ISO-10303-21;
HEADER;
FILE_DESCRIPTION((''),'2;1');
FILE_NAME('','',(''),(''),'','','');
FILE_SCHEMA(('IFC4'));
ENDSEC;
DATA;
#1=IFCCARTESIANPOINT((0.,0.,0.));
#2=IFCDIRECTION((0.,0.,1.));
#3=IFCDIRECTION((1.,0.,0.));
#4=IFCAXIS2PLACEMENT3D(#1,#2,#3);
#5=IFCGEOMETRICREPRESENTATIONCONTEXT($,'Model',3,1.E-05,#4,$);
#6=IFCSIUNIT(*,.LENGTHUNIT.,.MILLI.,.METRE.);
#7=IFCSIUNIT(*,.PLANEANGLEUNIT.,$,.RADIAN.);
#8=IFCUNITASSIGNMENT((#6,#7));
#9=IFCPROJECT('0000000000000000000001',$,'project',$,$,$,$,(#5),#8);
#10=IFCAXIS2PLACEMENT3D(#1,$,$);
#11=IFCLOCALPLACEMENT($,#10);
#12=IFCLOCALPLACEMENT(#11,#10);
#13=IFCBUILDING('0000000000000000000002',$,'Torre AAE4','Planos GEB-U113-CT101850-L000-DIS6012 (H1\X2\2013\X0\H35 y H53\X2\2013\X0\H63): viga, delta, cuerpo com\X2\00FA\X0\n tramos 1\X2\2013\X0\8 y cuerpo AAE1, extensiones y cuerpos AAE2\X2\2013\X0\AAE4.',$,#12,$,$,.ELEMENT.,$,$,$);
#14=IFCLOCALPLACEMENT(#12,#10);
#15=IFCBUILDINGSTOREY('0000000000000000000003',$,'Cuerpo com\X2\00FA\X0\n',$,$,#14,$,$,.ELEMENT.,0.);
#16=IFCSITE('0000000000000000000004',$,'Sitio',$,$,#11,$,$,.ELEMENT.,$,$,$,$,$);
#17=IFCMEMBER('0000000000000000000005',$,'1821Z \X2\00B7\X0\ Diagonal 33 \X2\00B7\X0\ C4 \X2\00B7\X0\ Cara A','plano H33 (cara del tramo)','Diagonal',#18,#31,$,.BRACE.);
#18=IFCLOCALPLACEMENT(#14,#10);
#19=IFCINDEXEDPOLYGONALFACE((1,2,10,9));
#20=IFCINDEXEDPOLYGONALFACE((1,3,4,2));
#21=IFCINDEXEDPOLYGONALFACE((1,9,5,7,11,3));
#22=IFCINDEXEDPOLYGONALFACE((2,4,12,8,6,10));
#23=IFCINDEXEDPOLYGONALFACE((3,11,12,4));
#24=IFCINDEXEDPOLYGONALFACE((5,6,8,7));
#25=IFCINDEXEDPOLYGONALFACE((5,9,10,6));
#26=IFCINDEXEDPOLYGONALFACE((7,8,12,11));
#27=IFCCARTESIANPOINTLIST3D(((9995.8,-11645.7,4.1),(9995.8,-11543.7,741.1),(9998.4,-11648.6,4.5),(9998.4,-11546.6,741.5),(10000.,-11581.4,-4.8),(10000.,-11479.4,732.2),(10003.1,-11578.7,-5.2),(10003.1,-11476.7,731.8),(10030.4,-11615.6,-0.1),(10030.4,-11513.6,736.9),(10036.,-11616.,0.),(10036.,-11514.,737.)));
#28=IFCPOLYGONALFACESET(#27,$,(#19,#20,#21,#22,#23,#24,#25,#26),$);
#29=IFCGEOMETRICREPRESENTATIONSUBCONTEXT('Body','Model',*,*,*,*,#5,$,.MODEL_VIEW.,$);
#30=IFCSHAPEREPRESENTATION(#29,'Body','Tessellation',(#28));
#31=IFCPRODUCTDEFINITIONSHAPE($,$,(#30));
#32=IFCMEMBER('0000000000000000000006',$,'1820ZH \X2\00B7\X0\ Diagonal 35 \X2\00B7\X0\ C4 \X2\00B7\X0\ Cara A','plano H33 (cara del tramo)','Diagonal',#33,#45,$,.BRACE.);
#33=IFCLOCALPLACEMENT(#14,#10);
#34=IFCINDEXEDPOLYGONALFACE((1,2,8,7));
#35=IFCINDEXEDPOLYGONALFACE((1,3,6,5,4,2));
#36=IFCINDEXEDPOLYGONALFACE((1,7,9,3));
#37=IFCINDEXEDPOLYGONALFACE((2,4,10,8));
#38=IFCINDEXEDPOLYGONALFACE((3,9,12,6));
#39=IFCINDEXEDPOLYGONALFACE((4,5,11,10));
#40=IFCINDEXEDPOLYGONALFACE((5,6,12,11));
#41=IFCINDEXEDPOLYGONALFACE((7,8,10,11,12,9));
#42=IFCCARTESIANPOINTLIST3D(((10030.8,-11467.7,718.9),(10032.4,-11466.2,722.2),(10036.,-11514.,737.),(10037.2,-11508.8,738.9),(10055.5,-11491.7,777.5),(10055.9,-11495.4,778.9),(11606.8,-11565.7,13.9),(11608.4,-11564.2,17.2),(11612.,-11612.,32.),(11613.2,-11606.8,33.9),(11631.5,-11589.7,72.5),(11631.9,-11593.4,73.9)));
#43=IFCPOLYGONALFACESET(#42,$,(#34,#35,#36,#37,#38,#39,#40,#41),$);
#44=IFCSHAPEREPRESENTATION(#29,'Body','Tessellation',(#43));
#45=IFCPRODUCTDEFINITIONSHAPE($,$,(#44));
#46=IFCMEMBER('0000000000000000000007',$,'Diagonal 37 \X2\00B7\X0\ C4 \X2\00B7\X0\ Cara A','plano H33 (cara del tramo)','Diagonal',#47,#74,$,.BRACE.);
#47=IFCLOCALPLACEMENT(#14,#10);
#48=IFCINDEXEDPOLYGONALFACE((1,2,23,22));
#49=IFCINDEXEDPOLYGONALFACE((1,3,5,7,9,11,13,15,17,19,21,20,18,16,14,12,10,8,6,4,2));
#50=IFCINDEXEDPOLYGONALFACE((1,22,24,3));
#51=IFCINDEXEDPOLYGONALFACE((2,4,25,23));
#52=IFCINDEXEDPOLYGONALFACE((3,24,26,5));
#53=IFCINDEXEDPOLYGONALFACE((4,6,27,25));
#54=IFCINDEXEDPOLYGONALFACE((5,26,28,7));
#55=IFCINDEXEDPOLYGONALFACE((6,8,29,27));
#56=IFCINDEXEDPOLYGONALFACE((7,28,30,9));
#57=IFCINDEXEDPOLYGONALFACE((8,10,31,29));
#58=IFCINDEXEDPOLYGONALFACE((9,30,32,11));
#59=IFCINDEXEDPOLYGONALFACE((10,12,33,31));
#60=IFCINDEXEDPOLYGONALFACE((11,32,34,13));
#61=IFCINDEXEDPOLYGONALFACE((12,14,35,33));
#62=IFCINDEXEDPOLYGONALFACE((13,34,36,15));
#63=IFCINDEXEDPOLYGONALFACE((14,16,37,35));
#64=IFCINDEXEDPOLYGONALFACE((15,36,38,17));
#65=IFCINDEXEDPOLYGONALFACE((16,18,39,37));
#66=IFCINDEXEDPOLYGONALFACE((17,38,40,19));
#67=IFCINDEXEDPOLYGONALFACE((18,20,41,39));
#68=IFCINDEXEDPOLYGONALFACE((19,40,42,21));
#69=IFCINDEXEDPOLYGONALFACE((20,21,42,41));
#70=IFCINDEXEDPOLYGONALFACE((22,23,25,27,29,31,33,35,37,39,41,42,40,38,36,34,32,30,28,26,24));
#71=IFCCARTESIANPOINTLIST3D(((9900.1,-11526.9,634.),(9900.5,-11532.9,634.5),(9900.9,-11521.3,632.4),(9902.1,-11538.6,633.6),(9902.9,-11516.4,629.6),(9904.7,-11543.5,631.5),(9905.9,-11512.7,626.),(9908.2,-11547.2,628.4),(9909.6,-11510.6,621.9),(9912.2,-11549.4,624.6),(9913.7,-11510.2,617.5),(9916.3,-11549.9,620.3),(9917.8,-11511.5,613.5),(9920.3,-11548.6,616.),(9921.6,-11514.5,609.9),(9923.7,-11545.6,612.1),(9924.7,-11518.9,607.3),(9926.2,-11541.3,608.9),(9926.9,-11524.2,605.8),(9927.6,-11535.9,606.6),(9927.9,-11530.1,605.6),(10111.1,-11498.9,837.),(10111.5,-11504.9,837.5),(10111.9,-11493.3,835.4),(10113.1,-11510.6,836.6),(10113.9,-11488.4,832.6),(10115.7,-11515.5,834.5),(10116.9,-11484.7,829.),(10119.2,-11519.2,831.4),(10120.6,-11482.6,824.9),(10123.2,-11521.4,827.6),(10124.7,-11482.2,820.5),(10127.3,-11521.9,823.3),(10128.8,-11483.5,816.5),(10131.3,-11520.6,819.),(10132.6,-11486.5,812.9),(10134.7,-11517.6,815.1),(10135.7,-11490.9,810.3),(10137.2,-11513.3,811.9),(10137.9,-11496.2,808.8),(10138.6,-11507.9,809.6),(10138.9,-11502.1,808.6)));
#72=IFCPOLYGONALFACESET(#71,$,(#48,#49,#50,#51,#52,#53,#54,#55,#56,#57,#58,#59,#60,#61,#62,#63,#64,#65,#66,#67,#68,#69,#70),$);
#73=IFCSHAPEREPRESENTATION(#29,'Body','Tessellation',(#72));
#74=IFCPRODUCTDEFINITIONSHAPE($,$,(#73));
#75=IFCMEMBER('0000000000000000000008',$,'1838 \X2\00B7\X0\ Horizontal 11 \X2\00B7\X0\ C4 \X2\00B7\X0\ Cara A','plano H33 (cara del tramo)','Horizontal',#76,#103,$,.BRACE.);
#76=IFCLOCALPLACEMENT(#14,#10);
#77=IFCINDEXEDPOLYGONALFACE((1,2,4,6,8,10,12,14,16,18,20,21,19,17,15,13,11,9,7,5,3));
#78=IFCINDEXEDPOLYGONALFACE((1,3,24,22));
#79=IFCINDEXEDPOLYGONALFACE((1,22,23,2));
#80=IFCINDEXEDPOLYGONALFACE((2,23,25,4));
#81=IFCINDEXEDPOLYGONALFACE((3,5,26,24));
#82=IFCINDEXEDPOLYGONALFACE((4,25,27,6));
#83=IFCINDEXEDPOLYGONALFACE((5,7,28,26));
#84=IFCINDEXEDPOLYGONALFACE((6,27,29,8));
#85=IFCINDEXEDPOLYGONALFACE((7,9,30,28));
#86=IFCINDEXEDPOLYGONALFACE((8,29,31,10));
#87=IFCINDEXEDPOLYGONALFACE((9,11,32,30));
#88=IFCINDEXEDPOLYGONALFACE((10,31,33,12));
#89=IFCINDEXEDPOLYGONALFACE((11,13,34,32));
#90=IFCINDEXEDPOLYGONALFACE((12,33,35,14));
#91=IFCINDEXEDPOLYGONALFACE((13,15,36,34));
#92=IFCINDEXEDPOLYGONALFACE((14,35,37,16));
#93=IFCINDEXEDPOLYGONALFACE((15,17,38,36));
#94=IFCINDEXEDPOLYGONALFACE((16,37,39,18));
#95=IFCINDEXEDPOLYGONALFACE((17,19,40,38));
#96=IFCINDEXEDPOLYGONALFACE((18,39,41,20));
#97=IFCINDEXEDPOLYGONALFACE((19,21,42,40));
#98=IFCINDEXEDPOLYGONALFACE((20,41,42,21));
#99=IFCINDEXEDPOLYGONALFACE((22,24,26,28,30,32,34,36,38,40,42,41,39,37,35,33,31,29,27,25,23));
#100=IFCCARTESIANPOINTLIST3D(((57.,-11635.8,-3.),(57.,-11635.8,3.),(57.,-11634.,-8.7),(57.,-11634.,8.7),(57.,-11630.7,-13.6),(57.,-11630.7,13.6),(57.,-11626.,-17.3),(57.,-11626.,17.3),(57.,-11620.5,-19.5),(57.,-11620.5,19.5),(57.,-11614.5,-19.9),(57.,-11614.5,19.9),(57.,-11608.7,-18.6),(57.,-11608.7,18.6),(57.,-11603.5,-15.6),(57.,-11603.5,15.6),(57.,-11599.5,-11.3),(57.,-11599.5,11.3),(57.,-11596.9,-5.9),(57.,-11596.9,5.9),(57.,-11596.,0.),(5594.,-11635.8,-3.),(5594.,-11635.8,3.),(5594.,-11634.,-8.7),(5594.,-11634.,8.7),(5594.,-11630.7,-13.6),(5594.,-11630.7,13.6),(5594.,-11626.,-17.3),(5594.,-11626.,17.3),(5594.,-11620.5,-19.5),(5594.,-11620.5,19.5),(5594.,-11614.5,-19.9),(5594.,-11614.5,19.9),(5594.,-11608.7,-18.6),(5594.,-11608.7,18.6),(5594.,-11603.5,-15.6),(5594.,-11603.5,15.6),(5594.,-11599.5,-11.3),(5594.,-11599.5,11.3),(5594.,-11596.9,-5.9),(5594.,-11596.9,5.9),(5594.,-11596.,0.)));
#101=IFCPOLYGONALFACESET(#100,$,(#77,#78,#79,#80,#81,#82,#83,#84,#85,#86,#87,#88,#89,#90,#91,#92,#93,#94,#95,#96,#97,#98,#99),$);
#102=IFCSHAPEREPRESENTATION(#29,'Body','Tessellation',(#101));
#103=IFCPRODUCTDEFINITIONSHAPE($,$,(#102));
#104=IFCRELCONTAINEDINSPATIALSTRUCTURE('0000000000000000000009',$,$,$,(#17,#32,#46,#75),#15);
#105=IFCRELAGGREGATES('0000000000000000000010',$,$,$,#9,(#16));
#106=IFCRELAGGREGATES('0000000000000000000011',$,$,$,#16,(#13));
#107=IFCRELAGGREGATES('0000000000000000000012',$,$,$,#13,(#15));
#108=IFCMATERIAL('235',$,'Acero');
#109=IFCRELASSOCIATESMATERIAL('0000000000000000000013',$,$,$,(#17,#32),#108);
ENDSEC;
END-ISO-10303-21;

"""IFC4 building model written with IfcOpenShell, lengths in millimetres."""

from ifc_helpers import new_model, si_unit, frame, frame_2d, origin, origin_with_axes, place, context, subcontext, project, spatial, circle, l_section, extrude, material, element, save


model = new_model("IFC4")

# Units and contexts
model_context = context("Model", 3, precision=1e-05, world=origin_with_axes())
body_context = subcontext(model_context, "Body", "Model", "MODEL_VIEW")
ifc_project = project(units=[si_unit("LENGTHUNIT", "METRE", prefix="MILLI"), si_unit("PLANEANGLEUNIT", "RADIAN")], contexts=[model_context])

# Site, building, storey
site_placement = place(None, origin())
site = spatial("IfcSite", under=ifc_project, at=site_placement, Name="Sitio", CompositionType="ELEMENT")
building_placement = place(site_placement, origin())
building = spatial("IfcBuilding", under=site, at=building_placement, Name="Torre AAE4", Description="Planos GEB-U113-CT101850-L000-DIS6012 (H1–H35 y H53–H63): viga, delta, cuerpo común tramos 1–8 y cuerpo AAE1, extensiones y cuerpos AAE2–AAE4.", CompositionType="ELEMENT")
storey_placement = place(building_placement, origin())
storey = spatial("IfcBuildingStorey", under=building, at=storey_placement, Name="Cuerpo común", CompositionType="ELEMENT", Elevation=0.0)

# Members
ifc_material_1 = material(Name="235", Category="Acero")
member_1_placement = place(storey_placement, frame((10036.0, -11616.0, 0.0), z_axis=(0.0, 0.137092, 0.990558), x_axis=(-0.658957, 0.745079, -0.103118)))
element("IfcMember", 1, at=member_1_placement, inside=storey, material=ifc_material_1, Name="1821Z · Diagonal 33 · C4 · Cara A", Description="plano H33 (cara del tramo)", ObjectType="Diagonal", PredefinedType="BRACE", context=body_context, shape_type="SweptSolid", body=[
    extrude(l_section(Depth=50.0, Width=50.0, Thickness=4.0, at=frame_2d((25.0, 25.0))), None, (0.0, 0.0, 1.0), 744.0),
])
member_2_placement = place(storey_placement, frame((10036.0, -11514.0, 737.0), z_axis=(0.911363, -0.056671, -0.407684), x_axis=(-0.104438, 0.926224, -0.362218)))
element("IfcMember", 2, at=member_2_placement, inside=storey, material=ifc_material_1, Name="1820ZH · Diagonal 35 · C4 · Cara A", Description="plano H33 (cara del tramo)", ObjectType="Diagonal", PredefinedType="BRACE", context=body_context, shape_type="SweptSolid", body=[
    extrude(l_section(Depth=50.0, Width=50.0, Thickness=4.0, at=frame_2d((25.0, 25.0))), None, (0.0, 0.0, 1.0), 1729.3),
])
member_3_placement = place(storey_placement, frame((10125.0, -11502.0, 823.0), z_axis=(-0.717363, -0.095195, -0.690165), x_axis=(-0.403655, 0.864202, 0.300362)))
element("IfcMember", 3, at=member_3_placement, inside=storey, Name="Diagonal 37 · C4 · Cara A", Description="plano H33 (cara del tramo)", ObjectType="Diagonal", PredefinedType="BRACE", context=body_context, shape_type="SweptSolid", body=[
    extrude(circle(Radius=20.0), None, (0.0, 0.0, 1.0), 294.1),
])
member_4_placement = place(storey_placement, frame((57.0, -11616.0, 0.0), z_axis=(1.0, 0.0, 0.0), x_axis=(0.0, 1.0, 0.0)))
element("IfcMember", 4, at=member_4_placement, inside=storey, Name="1838 · Horizontal 11 · C4 · Cara A", Description="plano H33 (cara del tramo)", ObjectType="Horizontal", PredefinedType="BRACE", context=body_context, shape_type="SweptSolid", body=[
    extrude(circle(Radius=20.0), None, (0.0, 0.0, 1.0), 5537.0),
])

save(model, "model.ifc")
